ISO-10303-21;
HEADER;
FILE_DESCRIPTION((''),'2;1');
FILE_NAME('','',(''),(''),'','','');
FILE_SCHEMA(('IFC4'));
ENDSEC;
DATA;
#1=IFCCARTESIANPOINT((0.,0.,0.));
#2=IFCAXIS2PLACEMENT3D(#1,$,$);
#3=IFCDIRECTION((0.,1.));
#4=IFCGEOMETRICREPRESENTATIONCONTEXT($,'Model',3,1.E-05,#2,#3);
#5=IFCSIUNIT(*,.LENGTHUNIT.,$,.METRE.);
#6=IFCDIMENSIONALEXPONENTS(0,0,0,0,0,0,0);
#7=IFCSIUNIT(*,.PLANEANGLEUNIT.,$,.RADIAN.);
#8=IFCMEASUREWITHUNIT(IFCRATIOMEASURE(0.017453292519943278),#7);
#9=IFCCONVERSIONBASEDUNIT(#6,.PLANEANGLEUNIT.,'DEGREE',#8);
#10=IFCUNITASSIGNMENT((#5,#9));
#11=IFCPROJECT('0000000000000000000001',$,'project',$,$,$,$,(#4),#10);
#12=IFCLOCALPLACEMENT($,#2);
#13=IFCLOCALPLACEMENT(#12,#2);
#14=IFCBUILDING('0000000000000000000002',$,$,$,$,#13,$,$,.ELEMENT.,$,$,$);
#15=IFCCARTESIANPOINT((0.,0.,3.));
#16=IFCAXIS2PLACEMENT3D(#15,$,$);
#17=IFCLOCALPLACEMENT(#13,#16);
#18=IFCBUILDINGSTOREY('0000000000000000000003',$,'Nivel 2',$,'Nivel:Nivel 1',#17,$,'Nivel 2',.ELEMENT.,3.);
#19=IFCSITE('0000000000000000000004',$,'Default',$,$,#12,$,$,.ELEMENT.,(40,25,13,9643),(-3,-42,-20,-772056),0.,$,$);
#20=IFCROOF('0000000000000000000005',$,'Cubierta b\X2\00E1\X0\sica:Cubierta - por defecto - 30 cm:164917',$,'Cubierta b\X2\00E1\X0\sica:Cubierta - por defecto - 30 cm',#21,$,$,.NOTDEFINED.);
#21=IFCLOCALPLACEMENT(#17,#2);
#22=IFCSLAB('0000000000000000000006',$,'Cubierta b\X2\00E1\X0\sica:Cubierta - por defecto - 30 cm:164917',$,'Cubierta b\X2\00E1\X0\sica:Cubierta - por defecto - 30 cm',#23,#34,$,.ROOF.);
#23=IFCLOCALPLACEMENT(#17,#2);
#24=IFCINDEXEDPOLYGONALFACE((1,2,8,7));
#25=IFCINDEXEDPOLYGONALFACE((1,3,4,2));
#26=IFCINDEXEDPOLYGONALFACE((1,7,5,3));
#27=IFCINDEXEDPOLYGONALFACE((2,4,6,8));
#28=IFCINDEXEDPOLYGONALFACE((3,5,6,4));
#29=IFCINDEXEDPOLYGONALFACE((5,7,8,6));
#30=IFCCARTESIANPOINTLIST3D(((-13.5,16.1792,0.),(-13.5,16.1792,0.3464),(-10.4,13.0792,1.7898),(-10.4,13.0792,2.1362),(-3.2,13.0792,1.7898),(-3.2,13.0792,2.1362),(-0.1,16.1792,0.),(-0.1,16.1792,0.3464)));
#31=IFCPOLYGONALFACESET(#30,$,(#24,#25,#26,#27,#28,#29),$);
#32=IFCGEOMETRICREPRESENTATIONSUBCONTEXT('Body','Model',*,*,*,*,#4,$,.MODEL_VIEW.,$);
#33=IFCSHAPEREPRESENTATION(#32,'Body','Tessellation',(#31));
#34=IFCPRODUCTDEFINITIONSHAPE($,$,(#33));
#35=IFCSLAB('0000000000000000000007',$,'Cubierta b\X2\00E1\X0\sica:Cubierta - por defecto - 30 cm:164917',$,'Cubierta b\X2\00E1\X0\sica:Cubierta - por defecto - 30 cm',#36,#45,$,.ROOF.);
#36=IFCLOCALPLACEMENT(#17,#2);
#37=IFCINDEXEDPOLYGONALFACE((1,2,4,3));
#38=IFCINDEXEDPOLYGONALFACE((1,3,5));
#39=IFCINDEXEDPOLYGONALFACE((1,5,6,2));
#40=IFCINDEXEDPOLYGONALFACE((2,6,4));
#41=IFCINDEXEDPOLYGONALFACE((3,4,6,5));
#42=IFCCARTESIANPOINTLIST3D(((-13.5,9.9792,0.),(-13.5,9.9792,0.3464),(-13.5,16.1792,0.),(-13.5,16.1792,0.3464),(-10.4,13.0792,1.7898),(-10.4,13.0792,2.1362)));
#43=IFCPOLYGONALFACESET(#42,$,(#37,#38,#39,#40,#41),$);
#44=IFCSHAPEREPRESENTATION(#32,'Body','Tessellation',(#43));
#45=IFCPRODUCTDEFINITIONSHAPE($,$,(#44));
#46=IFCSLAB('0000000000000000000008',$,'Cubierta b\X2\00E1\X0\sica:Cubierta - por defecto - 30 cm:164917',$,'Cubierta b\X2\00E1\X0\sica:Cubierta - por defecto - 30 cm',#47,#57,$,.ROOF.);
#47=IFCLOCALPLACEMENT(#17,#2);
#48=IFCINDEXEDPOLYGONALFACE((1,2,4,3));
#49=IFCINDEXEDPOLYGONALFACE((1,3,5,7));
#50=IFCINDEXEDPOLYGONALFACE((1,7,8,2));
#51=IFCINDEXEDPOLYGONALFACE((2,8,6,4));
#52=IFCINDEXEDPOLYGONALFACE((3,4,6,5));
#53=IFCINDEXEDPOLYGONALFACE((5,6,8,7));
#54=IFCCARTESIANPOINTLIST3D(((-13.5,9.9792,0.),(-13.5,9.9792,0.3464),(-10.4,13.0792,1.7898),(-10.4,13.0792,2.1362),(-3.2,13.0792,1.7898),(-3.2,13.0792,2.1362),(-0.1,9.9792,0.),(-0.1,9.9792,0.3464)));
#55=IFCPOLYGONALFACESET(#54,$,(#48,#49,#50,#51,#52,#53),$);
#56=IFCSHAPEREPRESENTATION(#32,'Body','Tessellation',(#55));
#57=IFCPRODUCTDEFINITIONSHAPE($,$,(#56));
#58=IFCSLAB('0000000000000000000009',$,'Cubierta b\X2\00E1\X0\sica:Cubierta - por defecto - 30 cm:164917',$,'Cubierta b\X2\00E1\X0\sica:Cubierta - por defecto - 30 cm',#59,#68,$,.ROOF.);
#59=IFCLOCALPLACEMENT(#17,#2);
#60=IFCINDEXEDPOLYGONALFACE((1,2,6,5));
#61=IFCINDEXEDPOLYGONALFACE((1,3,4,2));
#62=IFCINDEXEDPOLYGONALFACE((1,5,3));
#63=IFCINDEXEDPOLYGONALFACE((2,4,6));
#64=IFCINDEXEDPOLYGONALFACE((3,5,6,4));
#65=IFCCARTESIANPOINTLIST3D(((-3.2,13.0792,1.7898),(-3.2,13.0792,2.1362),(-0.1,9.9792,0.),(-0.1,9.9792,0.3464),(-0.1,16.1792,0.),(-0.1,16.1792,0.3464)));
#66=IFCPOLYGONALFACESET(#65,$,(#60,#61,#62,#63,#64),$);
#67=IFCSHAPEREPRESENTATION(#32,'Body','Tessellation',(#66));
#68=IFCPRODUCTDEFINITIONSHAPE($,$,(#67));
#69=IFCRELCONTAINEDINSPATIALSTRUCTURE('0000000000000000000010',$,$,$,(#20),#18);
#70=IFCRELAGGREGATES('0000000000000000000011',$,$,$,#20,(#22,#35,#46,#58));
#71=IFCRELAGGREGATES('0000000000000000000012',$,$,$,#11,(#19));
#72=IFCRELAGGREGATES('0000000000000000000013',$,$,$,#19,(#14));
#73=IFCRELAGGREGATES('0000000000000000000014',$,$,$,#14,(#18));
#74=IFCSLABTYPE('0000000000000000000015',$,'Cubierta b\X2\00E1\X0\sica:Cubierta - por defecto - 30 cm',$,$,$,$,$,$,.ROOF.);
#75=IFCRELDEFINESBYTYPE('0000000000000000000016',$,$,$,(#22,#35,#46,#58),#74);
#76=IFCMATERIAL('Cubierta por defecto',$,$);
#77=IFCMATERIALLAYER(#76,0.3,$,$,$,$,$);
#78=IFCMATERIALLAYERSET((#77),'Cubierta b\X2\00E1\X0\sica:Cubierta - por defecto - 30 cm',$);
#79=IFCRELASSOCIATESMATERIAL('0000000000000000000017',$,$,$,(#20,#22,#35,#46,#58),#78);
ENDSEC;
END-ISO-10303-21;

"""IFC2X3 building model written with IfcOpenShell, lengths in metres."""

from ifc_helpers import new_model, entity, si_unit, converted_unit, direction, frame, origin, place, context, subcontext, project, spatial, polyline, outline, extrude, material, layer, layer_set, type_object, element, aggregate, save


model = new_model("IFC2X3")

# Units and contexts
model_context = context("Model", 3, precision=1e-05, world=origin(), true_north=direction((0.0, 1.0)))
body_context = subcontext(model_context, "Body", "Model", "MODEL_VIEW")
ifc_project = project(units=[si_unit("LENGTHUNIT", "METRE"), converted_unit("PLANEANGLEUNIT", "DEGREE", entity("IfcRatioMeasure", 0.017453292519943278), si_unit("PLANEANGLEUNIT", "RADIAN"), dimensions=[0, 0, 0, 0, 0, 0, 0])], contexts=[model_context])

# Site, building, storey
site_placement = place(None, origin())
site = spatial("IfcSite", under=ifc_project, at=site_placement, Name="Default", CompositionType="ELEMENT", RefLatitude=(40, 25, 13, 9643), RefLongitude=(-3, -42, -20, -772056), RefElevation=0.0)
building_placement = place(site_placement, origin())
building = spatial("IfcBuilding", under=site, at=building_placement, CompositionType="ELEMENT")
storey_placement = place(building_placement, frame((0.0, 0.0, 3.0)))
storey = spatial("IfcBuildingStorey", under=building, at=storey_placement, Name="Nivel 2", ObjectType="Nivel:Nivel 1", LongName="Nivel 2", CompositionType="ELEMENT", Elevation=3.0)

# Roof, slabs
ifc_material = material(Name="Cubierta por defecto")
ifc_layer = layer(ifc_material, 0.3)
ifc_layer_set = layer_set([ifc_layer], Name="Cubierta básica:Cubierta - por defecto - 30 cm")
roof_placement = place(storey_placement, frame((-13.5, 9.9792, 0.0)))
roof = element("IfcRoof", 1, at=roof_placement, inside=storey, material=ifc_layer_set, Name="Cubierta básica:Cubierta - por defecto - 30 cm:164917", ObjectType="Cubierta básica:Cubierta - por defecto - 30 cm", ShapeType="NOTDEFINED")
slab_type = type_object("IfcSlabType", Name="Cubierta básica:Cubierta - por defecto - 30 cm", PredefinedType="ROOF")
slab_1_placement = place(roof_placement, origin())
slab_1 = element("IfcSlab", 2, at=slab_1_placement, type_object=slab_type, material=ifc_layer_set, Name="Cubierta básica:Cubierta - por defecto - 30 cm:164917", ObjectType="Cubierta básica:Cubierta - por defecto - 30 cm", PredefinedType="ROOF", context=body_context, shape_type="SweptSolid", body=[
    extrude(outline(polyline([(6.7, 1.7898), (-6.7, 1.7898), (-3.6, -1.7898), (3.6, -1.7898), (6.7, 1.7898)])), frame((6.7, 4.65, 0.8949), z_axis=(0.0, 0.5, 0.866025), x_axis=(1.0, 0.0, 0.0)), (0.0, -0.5, 0.866025), 0.3464),
])
slab_2_placement = place(roof_placement, origin())
slab_2 = element("IfcSlab", 3, at=slab_2_placement, type_object=slab_type, material=ifc_layer_set, Name="Cubierta básica:Cubierta - por defecto - 30 cm:164917", ObjectType="Cubierta básica:Cubierta - por defecto - 30 cm", PredefinedType="ROOF", context=body_context, shape_type="SweptSolid", body=[
    extrude(outline(polyline([(-1.7898, 3.1), (-1.7898, -3.1), (1.7898, 0.0), (-1.7898, 3.1)])), frame((1.55, 3.1, 0.8949), z_axis=(-0.5, 0.0, 0.866025), x_axis=(0.866025, 0.0, 0.5)), (0.5, 0.0, 0.866025), 0.3464),
])
slab_3_placement = place(roof_placement, origin())
slab_3 = element("IfcSlab", 4, at=slab_3_placement, type_object=slab_type, material=ifc_layer_set, Name="Cubierta básica:Cubierta - por defecto - 30 cm:164917", ObjectType="Cubierta básica:Cubierta - por defecto - 30 cm", PredefinedType="ROOF", context=body_context, shape_type="SweptSolid", body=[
    extrude(outline(polyline([(-6.7, -1.7898), (6.7, -1.7898), (3.6, 1.7898), (-3.6, 1.7898), (-6.7, -1.7898)])), frame((6.7, 1.55, 0.8949), z_axis=(0.0, -0.5, 0.866025), x_axis=(1.0, 0.0, 0.0)), (0.0, 0.5, 0.866025), 0.3464),
])
slab_4_placement = place(roof_placement, origin())
slab_4 = element("IfcSlab", 5, at=slab_4_placement, type_object=slab_type, material=ifc_layer_set, Name="Cubierta básica:Cubierta - por defecto - 30 cm:164917", ObjectType="Cubierta básica:Cubierta - por defecto - 30 cm", PredefinedType="ROOF", context=body_context, shape_type="SweptSolid", body=[
    extrude(outline(polyline([(-1.7898, 0.0), (1.7898, -3.1), (1.7898, 3.1), (-1.7898, 0.0)])), frame((11.85, 3.1, 0.8949), z_axis=(0.5, 0.0, 0.866025), x_axis=(0.866025, 0.0, -0.5)), (-0.5, 0.0, 0.866025), 0.3464),
])
aggregate(roof, [slab_1, slab_2, slab_3, slab_4])

save(model, "model.ifc")
